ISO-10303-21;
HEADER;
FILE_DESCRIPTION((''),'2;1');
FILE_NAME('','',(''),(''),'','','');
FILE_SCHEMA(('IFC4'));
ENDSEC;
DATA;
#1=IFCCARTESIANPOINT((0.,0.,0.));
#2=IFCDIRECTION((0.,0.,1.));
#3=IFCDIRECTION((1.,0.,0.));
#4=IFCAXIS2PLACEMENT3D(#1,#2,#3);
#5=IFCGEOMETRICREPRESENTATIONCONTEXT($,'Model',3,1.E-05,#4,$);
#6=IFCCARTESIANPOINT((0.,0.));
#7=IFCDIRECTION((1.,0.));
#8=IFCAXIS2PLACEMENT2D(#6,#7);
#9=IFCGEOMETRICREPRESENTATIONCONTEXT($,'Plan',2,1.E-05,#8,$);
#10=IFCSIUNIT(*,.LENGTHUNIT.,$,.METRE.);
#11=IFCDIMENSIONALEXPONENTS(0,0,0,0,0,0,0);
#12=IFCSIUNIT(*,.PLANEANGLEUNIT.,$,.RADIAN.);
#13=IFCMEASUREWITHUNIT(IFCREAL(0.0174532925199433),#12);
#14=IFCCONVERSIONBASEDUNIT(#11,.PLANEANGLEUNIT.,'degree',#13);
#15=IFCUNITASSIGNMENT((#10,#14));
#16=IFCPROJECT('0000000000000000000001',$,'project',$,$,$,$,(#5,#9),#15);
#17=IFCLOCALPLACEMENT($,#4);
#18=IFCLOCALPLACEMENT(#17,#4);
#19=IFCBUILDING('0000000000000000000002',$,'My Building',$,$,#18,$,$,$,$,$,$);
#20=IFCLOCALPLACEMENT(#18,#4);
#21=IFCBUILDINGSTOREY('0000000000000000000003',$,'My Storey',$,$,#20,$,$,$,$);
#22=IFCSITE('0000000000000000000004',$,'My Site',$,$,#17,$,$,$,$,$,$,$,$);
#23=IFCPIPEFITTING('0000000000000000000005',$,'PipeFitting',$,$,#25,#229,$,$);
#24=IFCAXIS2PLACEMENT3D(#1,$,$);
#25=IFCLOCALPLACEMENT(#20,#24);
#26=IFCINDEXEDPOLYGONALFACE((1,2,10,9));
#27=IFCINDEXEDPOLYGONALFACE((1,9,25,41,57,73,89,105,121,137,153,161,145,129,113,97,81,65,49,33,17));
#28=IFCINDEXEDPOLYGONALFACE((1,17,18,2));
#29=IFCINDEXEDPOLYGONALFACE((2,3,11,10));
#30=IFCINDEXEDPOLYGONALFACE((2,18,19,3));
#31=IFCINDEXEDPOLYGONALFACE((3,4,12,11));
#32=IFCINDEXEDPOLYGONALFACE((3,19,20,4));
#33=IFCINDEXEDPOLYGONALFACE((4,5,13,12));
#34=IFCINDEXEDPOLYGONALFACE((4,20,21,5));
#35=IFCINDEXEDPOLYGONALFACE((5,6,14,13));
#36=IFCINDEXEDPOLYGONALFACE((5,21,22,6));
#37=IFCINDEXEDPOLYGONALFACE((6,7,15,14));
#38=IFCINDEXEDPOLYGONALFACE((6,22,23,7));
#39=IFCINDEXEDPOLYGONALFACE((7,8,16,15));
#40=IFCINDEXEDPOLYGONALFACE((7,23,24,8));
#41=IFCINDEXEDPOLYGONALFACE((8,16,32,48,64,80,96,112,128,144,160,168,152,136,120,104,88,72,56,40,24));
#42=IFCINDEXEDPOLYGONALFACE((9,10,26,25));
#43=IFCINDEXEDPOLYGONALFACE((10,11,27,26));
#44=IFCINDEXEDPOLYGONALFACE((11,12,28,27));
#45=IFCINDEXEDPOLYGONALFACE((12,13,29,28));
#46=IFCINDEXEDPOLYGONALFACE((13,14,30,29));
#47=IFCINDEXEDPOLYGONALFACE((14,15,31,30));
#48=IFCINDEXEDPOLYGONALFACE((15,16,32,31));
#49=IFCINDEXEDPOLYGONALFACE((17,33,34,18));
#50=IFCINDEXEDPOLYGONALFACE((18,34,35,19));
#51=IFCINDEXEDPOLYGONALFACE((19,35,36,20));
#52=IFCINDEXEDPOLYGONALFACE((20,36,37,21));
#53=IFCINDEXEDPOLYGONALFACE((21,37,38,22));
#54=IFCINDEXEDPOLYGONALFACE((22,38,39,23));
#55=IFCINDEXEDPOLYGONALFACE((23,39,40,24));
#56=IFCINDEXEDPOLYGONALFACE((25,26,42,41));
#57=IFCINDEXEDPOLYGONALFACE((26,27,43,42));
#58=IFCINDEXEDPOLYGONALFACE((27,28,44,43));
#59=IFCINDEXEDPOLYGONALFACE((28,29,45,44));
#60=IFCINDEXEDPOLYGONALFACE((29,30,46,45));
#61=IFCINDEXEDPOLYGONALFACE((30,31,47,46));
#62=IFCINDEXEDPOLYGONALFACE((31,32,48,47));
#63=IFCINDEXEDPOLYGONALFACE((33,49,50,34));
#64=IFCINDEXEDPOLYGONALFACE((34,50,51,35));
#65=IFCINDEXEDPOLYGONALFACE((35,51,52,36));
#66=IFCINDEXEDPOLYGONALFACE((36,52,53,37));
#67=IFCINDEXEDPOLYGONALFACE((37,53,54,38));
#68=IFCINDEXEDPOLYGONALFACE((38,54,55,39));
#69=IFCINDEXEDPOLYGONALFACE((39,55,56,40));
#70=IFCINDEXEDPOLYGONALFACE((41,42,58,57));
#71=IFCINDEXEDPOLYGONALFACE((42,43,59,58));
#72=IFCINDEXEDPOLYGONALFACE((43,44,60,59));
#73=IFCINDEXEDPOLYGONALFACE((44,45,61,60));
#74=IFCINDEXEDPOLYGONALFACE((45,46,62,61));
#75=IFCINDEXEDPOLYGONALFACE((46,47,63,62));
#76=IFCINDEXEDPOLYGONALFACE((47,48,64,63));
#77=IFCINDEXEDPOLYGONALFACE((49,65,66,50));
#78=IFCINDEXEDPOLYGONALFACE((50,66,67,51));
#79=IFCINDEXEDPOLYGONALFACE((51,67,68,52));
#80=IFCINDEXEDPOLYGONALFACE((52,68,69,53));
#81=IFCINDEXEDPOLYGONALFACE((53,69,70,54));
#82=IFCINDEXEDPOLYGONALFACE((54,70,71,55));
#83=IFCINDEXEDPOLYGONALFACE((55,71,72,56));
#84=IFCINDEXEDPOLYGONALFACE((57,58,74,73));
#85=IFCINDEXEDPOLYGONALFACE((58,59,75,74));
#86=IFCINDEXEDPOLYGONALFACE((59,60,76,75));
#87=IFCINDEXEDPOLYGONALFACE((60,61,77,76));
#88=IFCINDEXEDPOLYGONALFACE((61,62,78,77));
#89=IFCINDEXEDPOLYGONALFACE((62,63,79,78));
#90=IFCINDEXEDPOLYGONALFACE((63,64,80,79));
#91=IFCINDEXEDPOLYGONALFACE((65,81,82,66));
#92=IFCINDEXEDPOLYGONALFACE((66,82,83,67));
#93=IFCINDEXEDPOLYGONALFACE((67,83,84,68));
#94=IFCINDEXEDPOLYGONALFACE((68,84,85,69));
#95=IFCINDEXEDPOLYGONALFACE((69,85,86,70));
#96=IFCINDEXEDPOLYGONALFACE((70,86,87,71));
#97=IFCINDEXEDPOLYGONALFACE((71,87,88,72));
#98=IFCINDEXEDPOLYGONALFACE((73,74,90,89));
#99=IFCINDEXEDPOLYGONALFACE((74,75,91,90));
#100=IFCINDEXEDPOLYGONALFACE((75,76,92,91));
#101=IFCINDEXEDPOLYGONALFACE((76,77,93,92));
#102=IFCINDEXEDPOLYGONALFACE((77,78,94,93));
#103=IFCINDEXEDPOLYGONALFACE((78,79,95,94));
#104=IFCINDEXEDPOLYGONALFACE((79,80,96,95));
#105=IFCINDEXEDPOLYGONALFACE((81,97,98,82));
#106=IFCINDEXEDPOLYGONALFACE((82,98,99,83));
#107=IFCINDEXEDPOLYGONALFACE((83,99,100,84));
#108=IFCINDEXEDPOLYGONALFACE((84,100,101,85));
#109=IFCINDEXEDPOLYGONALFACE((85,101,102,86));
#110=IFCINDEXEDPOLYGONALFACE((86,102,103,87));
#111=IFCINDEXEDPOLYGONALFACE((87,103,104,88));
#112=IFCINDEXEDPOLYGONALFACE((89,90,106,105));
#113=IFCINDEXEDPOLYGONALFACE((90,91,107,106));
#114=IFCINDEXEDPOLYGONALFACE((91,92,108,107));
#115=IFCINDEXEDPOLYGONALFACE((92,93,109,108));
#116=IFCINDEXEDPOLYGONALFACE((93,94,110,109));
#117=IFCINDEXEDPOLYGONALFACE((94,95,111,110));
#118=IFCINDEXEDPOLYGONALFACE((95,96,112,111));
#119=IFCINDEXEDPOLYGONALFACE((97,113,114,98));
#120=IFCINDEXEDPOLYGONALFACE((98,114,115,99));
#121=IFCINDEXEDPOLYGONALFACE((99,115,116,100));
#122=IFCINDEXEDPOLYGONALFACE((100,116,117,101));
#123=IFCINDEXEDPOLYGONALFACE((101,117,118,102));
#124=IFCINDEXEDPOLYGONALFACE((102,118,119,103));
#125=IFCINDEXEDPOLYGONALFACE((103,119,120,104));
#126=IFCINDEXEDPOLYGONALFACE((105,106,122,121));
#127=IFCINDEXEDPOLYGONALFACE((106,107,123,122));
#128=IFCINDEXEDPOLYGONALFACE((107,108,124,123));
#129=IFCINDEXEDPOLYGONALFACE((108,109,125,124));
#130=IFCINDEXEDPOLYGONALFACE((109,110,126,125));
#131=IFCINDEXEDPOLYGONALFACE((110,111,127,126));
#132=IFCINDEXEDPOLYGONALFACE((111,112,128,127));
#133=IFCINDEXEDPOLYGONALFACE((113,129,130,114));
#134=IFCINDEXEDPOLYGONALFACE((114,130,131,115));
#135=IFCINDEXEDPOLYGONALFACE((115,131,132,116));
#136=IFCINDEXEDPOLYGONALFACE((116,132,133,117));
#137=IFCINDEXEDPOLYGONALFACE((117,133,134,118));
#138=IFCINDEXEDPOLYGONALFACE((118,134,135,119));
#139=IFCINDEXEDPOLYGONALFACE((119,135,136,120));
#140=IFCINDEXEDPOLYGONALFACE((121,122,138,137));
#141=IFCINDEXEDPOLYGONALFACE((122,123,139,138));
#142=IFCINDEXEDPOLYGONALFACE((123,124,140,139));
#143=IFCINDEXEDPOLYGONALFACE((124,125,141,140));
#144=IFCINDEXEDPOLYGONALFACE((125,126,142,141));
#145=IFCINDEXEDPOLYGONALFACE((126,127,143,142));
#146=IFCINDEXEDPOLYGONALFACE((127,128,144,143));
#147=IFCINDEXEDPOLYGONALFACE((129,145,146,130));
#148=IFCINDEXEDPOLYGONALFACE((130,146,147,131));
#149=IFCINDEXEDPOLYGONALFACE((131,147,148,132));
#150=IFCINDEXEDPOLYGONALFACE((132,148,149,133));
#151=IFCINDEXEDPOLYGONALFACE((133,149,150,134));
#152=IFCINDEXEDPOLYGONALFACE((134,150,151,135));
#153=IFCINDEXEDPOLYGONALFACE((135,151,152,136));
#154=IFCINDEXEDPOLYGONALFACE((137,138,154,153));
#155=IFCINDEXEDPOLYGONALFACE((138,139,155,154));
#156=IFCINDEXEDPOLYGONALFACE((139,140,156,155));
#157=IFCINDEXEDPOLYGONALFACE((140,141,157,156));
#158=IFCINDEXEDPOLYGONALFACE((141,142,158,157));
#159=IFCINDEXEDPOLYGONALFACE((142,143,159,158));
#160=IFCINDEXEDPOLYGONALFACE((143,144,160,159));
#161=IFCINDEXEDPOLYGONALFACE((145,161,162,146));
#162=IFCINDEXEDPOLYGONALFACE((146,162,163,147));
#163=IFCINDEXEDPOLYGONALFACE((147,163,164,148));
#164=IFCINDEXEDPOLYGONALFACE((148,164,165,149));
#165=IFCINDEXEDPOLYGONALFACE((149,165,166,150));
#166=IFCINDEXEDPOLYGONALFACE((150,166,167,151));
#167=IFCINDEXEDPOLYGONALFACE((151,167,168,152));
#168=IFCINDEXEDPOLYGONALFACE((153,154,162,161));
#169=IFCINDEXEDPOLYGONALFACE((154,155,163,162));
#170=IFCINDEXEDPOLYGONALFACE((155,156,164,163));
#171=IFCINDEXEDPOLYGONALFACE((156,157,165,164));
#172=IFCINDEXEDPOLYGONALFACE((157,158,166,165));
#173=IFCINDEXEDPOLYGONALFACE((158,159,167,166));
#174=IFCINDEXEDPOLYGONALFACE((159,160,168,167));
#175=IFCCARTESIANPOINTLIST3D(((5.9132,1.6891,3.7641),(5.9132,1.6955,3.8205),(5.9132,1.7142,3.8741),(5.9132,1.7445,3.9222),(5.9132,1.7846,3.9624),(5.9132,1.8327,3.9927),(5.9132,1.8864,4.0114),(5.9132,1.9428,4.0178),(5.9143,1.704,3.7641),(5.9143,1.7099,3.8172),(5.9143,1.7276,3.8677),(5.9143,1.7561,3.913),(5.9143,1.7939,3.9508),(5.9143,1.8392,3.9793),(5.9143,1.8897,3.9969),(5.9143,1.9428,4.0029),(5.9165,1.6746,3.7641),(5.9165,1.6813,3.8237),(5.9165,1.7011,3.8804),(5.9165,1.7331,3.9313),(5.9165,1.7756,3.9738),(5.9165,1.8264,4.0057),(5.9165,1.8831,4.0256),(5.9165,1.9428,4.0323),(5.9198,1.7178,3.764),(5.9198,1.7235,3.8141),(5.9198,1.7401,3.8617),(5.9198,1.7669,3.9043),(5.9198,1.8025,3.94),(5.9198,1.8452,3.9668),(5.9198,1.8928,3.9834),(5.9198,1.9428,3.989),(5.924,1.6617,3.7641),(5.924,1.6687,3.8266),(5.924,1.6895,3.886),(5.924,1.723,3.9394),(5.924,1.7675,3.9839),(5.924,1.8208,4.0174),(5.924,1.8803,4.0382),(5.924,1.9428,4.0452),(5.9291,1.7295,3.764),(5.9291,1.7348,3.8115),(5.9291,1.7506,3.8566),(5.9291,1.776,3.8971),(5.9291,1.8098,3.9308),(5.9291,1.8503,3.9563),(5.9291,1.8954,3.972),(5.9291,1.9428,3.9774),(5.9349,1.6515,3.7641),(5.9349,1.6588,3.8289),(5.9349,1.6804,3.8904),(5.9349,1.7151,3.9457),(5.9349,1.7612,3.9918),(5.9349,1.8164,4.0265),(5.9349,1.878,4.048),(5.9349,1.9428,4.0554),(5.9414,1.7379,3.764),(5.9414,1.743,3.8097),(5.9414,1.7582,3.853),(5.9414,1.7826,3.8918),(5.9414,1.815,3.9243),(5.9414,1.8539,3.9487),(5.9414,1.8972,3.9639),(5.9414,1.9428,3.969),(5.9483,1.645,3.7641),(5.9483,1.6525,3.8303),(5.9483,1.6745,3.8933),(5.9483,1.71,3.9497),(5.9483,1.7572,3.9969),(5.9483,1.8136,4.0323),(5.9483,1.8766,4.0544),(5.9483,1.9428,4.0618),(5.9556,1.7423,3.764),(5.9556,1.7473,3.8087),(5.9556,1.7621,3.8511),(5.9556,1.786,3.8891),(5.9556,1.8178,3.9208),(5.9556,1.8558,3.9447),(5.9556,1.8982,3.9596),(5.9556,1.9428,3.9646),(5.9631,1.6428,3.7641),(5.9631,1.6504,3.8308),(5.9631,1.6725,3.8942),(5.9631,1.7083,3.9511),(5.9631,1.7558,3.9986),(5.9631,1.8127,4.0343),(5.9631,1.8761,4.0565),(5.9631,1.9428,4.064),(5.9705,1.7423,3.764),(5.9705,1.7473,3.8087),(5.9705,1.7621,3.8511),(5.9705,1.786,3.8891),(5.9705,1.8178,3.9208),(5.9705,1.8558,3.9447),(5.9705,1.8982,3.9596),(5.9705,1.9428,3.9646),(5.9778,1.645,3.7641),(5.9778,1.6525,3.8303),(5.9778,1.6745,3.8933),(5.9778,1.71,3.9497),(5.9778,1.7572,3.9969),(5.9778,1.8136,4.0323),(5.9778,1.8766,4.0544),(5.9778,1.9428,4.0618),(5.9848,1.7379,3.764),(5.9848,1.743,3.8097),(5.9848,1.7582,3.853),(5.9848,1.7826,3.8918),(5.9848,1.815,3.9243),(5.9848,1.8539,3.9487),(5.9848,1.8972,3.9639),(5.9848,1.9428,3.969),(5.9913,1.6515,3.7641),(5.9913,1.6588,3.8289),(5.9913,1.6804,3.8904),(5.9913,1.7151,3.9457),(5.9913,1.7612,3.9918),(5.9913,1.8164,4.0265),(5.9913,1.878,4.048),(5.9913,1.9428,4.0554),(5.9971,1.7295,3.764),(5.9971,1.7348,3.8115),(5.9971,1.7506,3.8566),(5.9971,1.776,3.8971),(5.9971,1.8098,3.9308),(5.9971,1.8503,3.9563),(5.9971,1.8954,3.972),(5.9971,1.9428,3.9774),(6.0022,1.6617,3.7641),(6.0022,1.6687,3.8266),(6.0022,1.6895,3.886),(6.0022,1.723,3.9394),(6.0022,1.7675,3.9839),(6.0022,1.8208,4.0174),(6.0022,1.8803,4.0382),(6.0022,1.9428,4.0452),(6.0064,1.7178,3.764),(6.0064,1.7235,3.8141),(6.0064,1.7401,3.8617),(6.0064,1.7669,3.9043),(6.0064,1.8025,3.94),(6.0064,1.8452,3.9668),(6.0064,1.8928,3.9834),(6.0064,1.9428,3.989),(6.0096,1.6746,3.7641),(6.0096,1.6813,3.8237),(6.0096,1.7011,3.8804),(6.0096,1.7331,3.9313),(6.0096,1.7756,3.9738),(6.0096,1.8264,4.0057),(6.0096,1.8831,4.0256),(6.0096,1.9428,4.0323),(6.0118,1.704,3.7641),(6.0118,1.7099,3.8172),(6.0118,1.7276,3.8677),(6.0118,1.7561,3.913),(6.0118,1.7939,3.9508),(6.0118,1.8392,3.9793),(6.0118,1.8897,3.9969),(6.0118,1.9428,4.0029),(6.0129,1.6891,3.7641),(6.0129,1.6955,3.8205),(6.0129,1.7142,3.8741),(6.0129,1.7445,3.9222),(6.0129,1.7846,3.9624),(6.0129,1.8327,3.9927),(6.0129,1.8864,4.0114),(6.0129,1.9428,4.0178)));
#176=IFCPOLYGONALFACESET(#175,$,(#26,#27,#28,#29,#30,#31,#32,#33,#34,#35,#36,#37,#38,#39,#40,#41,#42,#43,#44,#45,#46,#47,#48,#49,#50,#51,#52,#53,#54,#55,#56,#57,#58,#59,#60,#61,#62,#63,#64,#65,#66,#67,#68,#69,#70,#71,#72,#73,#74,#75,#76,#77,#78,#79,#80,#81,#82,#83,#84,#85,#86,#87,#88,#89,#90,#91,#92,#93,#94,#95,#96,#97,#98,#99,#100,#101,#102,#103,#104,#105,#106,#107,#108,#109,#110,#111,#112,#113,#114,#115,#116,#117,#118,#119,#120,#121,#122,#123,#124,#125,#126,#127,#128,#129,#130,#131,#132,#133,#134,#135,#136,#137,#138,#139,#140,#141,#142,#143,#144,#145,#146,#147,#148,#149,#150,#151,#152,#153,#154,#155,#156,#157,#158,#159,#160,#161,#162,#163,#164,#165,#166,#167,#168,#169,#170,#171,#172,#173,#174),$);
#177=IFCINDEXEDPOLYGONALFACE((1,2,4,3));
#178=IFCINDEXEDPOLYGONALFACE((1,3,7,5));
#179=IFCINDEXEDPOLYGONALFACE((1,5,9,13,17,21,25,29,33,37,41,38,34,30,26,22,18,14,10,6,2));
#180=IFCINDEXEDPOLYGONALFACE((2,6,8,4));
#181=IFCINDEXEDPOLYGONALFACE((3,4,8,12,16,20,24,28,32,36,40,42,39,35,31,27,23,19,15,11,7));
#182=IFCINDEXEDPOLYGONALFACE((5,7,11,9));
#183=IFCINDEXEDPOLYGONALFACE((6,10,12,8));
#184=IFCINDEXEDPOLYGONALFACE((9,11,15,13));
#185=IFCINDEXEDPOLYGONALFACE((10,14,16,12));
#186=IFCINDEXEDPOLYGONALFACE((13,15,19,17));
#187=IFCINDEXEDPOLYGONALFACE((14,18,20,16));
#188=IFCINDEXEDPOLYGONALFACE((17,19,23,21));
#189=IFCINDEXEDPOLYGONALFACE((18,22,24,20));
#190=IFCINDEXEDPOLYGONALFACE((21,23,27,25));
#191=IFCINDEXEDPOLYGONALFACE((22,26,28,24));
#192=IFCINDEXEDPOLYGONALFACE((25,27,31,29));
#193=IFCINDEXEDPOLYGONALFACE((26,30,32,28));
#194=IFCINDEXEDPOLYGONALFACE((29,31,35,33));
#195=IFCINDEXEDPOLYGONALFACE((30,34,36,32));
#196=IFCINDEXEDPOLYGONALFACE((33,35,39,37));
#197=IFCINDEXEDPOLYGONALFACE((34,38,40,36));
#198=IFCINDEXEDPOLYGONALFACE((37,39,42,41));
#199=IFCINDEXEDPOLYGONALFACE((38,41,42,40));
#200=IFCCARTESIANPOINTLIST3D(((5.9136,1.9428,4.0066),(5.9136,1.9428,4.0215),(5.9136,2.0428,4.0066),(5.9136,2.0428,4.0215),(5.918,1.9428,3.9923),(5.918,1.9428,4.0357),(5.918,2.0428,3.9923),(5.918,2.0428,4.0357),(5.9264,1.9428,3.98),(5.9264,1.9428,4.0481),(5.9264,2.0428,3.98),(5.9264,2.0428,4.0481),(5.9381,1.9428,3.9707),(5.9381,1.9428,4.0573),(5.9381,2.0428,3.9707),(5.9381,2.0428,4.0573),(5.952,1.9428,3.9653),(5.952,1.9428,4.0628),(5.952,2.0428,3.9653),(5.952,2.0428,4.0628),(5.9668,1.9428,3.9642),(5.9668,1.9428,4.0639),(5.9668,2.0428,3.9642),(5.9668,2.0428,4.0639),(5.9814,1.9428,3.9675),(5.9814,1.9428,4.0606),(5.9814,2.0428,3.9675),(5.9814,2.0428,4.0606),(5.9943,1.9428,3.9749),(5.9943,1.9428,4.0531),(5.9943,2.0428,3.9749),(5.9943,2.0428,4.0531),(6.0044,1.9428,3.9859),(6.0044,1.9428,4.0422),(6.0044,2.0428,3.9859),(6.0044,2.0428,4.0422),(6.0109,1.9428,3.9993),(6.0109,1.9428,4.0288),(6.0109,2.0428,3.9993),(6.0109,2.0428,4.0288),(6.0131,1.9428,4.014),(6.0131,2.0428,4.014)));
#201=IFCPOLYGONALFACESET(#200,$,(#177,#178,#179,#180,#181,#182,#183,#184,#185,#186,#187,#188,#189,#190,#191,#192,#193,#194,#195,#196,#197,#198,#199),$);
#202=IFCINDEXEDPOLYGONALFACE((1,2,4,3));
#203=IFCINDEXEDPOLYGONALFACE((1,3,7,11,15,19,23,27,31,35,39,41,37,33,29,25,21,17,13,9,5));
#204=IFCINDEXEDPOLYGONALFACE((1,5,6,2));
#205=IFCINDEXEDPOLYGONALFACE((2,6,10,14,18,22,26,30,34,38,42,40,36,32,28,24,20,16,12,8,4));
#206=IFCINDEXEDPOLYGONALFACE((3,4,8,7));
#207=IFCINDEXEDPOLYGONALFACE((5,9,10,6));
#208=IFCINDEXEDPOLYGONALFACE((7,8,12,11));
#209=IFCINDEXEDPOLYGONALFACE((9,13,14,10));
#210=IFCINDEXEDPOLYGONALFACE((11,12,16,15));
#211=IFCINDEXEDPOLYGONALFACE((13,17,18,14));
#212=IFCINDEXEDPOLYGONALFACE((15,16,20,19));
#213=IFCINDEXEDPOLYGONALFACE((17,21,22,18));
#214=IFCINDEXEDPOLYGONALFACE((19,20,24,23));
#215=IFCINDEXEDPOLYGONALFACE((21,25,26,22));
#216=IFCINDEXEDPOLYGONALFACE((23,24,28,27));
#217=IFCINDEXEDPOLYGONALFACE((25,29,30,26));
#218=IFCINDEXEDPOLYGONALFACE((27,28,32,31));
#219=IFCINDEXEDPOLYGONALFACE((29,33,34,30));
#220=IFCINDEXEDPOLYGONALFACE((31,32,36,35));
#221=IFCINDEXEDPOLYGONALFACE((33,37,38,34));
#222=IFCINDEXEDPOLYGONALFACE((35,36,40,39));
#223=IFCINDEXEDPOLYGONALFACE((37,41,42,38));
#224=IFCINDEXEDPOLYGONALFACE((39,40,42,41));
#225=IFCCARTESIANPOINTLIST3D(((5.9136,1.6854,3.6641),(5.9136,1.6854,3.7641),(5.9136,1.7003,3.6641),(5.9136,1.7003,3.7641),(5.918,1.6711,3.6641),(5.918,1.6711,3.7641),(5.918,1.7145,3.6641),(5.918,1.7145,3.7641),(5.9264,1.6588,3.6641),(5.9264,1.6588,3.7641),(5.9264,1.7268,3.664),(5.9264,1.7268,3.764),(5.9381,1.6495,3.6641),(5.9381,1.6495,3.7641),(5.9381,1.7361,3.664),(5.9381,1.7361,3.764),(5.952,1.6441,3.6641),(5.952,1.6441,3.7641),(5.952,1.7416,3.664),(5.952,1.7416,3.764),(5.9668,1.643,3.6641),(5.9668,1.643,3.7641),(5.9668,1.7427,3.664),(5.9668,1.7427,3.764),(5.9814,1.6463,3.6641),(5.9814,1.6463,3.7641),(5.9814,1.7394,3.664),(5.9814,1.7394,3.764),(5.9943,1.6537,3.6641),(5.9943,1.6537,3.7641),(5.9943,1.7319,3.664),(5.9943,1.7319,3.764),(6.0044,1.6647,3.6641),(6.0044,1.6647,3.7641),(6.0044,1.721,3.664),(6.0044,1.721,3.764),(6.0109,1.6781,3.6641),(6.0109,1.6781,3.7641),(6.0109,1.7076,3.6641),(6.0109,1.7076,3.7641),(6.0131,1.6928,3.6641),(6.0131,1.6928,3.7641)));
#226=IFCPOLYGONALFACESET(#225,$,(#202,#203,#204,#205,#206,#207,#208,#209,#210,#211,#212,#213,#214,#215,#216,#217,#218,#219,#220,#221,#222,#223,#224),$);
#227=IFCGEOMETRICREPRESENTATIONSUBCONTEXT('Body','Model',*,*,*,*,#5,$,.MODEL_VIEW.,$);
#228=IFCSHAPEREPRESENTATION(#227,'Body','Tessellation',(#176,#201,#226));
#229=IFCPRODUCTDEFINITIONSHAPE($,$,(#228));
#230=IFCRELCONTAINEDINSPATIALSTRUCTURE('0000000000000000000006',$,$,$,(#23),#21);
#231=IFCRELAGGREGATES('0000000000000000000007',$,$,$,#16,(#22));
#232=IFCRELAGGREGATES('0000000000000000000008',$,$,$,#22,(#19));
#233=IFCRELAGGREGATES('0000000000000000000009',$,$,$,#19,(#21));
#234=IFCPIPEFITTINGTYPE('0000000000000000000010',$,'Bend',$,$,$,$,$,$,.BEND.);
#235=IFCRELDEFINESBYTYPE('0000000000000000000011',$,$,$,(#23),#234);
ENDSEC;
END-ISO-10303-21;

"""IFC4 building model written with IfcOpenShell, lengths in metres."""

from ifc_helpers import new_model, entity, si_unit, converted_unit, frame, origin_with_axes, origin_2d_with_axis, place, context, subcontext, project, spatial, circle, extrude, source, transform, mapped, type_object, type_shapes, element, save


model = new_model("IFC4")

# Units and contexts
model_context = context("Model", 3, precision=1e-05, world=origin_with_axes())
plan_context = context("Plan", 2, precision=1e-05, world=origin_2d_with_axis())
body_context = subcontext(model_context, "Body", "Model", "MODEL_VIEW")
ifc_project = project(units=[si_unit("LENGTHUNIT", "METRE"), converted_unit("PLANEANGLEUNIT", "degree", entity("IfcReal", 0.0174532925199433), si_unit("PLANEANGLEUNIT", "RADIAN"), dimensions=[0, 0, 0, 0, 0, 0, 0])], contexts=[model_context, plan_context])

# Site, building, storey
site_placement = place(None, origin_with_axes())
site = spatial("IfcSite", under=ifc_project, at=site_placement, Name="My Site")
building_placement = place(site_placement, origin_with_axes())
building = spatial("IfcBuilding", under=site, at=building_placement, Name="My Building")
storey_placement = place(building_placement, origin_with_axes())
storey = spatial("IfcBuildingStorey", under=building, at=storey_placement, Name="My Storey")

# Pipe fitting
pipe_fitting_type_1 = type_object("IfcPipeFittingType", Name="Bend", PredefinedType="BEND")
shared_shape_1 = source(origin_with_axes(), body_context, "Body", "SolidModel", [
    entity("IfcSweptDiskSolid", entity("IfcIndexedPolyCurve", entity("IfcCartesianPointList3D", [[0.0, 0.0, 0.1], [0.0, -0.0732, 0.2768], [0.0, -0.25, 0.35]]), [entity("IfcArcIndex", [1, 2, 3])]), 0.05),
    extrude(circle(Radius=0.05), origin_with_axes(), (0.0, 0.0, 1.0), 0.1),
    extrude(circle(Radius=0.05), frame((0.0, -0.25, 0.35), z_axis=(0.0, -1.0, 0.000038), x_axis=(1.0, 0.0, 0.0)), (0.0, 0.0, 1.0), 0.1),
])
type_shapes(pipe_fitting_type_1, [shared_shape_1])
for number, where, z_axis, x_axis, name in (
    (1, (5.9631, 2.0428, 4.014), (0.0, -1.0, 0.0), (1.0, 0.0, 0.0), "PipeFitting"),
):
    element("IfcPipeFitting", number, at=place(storey_placement, frame(where, z_axis=z_axis, x_axis=x_axis)), inside=storey, type_object=pipe_fitting_type_1, Name=name, context=body_context, shape_type="MappedRepresentation", body=[
        mapped(shared_shape_1, transform((0.0, 0.0, 0.0), x_axis=(1.0, 0.0, 0.0), y_axis=(0.0, 1.0, 0.0), z_axis=(0.0, 0.0, 1.0), scale=1.0)),
    ])

save(model, "model.ifc")
